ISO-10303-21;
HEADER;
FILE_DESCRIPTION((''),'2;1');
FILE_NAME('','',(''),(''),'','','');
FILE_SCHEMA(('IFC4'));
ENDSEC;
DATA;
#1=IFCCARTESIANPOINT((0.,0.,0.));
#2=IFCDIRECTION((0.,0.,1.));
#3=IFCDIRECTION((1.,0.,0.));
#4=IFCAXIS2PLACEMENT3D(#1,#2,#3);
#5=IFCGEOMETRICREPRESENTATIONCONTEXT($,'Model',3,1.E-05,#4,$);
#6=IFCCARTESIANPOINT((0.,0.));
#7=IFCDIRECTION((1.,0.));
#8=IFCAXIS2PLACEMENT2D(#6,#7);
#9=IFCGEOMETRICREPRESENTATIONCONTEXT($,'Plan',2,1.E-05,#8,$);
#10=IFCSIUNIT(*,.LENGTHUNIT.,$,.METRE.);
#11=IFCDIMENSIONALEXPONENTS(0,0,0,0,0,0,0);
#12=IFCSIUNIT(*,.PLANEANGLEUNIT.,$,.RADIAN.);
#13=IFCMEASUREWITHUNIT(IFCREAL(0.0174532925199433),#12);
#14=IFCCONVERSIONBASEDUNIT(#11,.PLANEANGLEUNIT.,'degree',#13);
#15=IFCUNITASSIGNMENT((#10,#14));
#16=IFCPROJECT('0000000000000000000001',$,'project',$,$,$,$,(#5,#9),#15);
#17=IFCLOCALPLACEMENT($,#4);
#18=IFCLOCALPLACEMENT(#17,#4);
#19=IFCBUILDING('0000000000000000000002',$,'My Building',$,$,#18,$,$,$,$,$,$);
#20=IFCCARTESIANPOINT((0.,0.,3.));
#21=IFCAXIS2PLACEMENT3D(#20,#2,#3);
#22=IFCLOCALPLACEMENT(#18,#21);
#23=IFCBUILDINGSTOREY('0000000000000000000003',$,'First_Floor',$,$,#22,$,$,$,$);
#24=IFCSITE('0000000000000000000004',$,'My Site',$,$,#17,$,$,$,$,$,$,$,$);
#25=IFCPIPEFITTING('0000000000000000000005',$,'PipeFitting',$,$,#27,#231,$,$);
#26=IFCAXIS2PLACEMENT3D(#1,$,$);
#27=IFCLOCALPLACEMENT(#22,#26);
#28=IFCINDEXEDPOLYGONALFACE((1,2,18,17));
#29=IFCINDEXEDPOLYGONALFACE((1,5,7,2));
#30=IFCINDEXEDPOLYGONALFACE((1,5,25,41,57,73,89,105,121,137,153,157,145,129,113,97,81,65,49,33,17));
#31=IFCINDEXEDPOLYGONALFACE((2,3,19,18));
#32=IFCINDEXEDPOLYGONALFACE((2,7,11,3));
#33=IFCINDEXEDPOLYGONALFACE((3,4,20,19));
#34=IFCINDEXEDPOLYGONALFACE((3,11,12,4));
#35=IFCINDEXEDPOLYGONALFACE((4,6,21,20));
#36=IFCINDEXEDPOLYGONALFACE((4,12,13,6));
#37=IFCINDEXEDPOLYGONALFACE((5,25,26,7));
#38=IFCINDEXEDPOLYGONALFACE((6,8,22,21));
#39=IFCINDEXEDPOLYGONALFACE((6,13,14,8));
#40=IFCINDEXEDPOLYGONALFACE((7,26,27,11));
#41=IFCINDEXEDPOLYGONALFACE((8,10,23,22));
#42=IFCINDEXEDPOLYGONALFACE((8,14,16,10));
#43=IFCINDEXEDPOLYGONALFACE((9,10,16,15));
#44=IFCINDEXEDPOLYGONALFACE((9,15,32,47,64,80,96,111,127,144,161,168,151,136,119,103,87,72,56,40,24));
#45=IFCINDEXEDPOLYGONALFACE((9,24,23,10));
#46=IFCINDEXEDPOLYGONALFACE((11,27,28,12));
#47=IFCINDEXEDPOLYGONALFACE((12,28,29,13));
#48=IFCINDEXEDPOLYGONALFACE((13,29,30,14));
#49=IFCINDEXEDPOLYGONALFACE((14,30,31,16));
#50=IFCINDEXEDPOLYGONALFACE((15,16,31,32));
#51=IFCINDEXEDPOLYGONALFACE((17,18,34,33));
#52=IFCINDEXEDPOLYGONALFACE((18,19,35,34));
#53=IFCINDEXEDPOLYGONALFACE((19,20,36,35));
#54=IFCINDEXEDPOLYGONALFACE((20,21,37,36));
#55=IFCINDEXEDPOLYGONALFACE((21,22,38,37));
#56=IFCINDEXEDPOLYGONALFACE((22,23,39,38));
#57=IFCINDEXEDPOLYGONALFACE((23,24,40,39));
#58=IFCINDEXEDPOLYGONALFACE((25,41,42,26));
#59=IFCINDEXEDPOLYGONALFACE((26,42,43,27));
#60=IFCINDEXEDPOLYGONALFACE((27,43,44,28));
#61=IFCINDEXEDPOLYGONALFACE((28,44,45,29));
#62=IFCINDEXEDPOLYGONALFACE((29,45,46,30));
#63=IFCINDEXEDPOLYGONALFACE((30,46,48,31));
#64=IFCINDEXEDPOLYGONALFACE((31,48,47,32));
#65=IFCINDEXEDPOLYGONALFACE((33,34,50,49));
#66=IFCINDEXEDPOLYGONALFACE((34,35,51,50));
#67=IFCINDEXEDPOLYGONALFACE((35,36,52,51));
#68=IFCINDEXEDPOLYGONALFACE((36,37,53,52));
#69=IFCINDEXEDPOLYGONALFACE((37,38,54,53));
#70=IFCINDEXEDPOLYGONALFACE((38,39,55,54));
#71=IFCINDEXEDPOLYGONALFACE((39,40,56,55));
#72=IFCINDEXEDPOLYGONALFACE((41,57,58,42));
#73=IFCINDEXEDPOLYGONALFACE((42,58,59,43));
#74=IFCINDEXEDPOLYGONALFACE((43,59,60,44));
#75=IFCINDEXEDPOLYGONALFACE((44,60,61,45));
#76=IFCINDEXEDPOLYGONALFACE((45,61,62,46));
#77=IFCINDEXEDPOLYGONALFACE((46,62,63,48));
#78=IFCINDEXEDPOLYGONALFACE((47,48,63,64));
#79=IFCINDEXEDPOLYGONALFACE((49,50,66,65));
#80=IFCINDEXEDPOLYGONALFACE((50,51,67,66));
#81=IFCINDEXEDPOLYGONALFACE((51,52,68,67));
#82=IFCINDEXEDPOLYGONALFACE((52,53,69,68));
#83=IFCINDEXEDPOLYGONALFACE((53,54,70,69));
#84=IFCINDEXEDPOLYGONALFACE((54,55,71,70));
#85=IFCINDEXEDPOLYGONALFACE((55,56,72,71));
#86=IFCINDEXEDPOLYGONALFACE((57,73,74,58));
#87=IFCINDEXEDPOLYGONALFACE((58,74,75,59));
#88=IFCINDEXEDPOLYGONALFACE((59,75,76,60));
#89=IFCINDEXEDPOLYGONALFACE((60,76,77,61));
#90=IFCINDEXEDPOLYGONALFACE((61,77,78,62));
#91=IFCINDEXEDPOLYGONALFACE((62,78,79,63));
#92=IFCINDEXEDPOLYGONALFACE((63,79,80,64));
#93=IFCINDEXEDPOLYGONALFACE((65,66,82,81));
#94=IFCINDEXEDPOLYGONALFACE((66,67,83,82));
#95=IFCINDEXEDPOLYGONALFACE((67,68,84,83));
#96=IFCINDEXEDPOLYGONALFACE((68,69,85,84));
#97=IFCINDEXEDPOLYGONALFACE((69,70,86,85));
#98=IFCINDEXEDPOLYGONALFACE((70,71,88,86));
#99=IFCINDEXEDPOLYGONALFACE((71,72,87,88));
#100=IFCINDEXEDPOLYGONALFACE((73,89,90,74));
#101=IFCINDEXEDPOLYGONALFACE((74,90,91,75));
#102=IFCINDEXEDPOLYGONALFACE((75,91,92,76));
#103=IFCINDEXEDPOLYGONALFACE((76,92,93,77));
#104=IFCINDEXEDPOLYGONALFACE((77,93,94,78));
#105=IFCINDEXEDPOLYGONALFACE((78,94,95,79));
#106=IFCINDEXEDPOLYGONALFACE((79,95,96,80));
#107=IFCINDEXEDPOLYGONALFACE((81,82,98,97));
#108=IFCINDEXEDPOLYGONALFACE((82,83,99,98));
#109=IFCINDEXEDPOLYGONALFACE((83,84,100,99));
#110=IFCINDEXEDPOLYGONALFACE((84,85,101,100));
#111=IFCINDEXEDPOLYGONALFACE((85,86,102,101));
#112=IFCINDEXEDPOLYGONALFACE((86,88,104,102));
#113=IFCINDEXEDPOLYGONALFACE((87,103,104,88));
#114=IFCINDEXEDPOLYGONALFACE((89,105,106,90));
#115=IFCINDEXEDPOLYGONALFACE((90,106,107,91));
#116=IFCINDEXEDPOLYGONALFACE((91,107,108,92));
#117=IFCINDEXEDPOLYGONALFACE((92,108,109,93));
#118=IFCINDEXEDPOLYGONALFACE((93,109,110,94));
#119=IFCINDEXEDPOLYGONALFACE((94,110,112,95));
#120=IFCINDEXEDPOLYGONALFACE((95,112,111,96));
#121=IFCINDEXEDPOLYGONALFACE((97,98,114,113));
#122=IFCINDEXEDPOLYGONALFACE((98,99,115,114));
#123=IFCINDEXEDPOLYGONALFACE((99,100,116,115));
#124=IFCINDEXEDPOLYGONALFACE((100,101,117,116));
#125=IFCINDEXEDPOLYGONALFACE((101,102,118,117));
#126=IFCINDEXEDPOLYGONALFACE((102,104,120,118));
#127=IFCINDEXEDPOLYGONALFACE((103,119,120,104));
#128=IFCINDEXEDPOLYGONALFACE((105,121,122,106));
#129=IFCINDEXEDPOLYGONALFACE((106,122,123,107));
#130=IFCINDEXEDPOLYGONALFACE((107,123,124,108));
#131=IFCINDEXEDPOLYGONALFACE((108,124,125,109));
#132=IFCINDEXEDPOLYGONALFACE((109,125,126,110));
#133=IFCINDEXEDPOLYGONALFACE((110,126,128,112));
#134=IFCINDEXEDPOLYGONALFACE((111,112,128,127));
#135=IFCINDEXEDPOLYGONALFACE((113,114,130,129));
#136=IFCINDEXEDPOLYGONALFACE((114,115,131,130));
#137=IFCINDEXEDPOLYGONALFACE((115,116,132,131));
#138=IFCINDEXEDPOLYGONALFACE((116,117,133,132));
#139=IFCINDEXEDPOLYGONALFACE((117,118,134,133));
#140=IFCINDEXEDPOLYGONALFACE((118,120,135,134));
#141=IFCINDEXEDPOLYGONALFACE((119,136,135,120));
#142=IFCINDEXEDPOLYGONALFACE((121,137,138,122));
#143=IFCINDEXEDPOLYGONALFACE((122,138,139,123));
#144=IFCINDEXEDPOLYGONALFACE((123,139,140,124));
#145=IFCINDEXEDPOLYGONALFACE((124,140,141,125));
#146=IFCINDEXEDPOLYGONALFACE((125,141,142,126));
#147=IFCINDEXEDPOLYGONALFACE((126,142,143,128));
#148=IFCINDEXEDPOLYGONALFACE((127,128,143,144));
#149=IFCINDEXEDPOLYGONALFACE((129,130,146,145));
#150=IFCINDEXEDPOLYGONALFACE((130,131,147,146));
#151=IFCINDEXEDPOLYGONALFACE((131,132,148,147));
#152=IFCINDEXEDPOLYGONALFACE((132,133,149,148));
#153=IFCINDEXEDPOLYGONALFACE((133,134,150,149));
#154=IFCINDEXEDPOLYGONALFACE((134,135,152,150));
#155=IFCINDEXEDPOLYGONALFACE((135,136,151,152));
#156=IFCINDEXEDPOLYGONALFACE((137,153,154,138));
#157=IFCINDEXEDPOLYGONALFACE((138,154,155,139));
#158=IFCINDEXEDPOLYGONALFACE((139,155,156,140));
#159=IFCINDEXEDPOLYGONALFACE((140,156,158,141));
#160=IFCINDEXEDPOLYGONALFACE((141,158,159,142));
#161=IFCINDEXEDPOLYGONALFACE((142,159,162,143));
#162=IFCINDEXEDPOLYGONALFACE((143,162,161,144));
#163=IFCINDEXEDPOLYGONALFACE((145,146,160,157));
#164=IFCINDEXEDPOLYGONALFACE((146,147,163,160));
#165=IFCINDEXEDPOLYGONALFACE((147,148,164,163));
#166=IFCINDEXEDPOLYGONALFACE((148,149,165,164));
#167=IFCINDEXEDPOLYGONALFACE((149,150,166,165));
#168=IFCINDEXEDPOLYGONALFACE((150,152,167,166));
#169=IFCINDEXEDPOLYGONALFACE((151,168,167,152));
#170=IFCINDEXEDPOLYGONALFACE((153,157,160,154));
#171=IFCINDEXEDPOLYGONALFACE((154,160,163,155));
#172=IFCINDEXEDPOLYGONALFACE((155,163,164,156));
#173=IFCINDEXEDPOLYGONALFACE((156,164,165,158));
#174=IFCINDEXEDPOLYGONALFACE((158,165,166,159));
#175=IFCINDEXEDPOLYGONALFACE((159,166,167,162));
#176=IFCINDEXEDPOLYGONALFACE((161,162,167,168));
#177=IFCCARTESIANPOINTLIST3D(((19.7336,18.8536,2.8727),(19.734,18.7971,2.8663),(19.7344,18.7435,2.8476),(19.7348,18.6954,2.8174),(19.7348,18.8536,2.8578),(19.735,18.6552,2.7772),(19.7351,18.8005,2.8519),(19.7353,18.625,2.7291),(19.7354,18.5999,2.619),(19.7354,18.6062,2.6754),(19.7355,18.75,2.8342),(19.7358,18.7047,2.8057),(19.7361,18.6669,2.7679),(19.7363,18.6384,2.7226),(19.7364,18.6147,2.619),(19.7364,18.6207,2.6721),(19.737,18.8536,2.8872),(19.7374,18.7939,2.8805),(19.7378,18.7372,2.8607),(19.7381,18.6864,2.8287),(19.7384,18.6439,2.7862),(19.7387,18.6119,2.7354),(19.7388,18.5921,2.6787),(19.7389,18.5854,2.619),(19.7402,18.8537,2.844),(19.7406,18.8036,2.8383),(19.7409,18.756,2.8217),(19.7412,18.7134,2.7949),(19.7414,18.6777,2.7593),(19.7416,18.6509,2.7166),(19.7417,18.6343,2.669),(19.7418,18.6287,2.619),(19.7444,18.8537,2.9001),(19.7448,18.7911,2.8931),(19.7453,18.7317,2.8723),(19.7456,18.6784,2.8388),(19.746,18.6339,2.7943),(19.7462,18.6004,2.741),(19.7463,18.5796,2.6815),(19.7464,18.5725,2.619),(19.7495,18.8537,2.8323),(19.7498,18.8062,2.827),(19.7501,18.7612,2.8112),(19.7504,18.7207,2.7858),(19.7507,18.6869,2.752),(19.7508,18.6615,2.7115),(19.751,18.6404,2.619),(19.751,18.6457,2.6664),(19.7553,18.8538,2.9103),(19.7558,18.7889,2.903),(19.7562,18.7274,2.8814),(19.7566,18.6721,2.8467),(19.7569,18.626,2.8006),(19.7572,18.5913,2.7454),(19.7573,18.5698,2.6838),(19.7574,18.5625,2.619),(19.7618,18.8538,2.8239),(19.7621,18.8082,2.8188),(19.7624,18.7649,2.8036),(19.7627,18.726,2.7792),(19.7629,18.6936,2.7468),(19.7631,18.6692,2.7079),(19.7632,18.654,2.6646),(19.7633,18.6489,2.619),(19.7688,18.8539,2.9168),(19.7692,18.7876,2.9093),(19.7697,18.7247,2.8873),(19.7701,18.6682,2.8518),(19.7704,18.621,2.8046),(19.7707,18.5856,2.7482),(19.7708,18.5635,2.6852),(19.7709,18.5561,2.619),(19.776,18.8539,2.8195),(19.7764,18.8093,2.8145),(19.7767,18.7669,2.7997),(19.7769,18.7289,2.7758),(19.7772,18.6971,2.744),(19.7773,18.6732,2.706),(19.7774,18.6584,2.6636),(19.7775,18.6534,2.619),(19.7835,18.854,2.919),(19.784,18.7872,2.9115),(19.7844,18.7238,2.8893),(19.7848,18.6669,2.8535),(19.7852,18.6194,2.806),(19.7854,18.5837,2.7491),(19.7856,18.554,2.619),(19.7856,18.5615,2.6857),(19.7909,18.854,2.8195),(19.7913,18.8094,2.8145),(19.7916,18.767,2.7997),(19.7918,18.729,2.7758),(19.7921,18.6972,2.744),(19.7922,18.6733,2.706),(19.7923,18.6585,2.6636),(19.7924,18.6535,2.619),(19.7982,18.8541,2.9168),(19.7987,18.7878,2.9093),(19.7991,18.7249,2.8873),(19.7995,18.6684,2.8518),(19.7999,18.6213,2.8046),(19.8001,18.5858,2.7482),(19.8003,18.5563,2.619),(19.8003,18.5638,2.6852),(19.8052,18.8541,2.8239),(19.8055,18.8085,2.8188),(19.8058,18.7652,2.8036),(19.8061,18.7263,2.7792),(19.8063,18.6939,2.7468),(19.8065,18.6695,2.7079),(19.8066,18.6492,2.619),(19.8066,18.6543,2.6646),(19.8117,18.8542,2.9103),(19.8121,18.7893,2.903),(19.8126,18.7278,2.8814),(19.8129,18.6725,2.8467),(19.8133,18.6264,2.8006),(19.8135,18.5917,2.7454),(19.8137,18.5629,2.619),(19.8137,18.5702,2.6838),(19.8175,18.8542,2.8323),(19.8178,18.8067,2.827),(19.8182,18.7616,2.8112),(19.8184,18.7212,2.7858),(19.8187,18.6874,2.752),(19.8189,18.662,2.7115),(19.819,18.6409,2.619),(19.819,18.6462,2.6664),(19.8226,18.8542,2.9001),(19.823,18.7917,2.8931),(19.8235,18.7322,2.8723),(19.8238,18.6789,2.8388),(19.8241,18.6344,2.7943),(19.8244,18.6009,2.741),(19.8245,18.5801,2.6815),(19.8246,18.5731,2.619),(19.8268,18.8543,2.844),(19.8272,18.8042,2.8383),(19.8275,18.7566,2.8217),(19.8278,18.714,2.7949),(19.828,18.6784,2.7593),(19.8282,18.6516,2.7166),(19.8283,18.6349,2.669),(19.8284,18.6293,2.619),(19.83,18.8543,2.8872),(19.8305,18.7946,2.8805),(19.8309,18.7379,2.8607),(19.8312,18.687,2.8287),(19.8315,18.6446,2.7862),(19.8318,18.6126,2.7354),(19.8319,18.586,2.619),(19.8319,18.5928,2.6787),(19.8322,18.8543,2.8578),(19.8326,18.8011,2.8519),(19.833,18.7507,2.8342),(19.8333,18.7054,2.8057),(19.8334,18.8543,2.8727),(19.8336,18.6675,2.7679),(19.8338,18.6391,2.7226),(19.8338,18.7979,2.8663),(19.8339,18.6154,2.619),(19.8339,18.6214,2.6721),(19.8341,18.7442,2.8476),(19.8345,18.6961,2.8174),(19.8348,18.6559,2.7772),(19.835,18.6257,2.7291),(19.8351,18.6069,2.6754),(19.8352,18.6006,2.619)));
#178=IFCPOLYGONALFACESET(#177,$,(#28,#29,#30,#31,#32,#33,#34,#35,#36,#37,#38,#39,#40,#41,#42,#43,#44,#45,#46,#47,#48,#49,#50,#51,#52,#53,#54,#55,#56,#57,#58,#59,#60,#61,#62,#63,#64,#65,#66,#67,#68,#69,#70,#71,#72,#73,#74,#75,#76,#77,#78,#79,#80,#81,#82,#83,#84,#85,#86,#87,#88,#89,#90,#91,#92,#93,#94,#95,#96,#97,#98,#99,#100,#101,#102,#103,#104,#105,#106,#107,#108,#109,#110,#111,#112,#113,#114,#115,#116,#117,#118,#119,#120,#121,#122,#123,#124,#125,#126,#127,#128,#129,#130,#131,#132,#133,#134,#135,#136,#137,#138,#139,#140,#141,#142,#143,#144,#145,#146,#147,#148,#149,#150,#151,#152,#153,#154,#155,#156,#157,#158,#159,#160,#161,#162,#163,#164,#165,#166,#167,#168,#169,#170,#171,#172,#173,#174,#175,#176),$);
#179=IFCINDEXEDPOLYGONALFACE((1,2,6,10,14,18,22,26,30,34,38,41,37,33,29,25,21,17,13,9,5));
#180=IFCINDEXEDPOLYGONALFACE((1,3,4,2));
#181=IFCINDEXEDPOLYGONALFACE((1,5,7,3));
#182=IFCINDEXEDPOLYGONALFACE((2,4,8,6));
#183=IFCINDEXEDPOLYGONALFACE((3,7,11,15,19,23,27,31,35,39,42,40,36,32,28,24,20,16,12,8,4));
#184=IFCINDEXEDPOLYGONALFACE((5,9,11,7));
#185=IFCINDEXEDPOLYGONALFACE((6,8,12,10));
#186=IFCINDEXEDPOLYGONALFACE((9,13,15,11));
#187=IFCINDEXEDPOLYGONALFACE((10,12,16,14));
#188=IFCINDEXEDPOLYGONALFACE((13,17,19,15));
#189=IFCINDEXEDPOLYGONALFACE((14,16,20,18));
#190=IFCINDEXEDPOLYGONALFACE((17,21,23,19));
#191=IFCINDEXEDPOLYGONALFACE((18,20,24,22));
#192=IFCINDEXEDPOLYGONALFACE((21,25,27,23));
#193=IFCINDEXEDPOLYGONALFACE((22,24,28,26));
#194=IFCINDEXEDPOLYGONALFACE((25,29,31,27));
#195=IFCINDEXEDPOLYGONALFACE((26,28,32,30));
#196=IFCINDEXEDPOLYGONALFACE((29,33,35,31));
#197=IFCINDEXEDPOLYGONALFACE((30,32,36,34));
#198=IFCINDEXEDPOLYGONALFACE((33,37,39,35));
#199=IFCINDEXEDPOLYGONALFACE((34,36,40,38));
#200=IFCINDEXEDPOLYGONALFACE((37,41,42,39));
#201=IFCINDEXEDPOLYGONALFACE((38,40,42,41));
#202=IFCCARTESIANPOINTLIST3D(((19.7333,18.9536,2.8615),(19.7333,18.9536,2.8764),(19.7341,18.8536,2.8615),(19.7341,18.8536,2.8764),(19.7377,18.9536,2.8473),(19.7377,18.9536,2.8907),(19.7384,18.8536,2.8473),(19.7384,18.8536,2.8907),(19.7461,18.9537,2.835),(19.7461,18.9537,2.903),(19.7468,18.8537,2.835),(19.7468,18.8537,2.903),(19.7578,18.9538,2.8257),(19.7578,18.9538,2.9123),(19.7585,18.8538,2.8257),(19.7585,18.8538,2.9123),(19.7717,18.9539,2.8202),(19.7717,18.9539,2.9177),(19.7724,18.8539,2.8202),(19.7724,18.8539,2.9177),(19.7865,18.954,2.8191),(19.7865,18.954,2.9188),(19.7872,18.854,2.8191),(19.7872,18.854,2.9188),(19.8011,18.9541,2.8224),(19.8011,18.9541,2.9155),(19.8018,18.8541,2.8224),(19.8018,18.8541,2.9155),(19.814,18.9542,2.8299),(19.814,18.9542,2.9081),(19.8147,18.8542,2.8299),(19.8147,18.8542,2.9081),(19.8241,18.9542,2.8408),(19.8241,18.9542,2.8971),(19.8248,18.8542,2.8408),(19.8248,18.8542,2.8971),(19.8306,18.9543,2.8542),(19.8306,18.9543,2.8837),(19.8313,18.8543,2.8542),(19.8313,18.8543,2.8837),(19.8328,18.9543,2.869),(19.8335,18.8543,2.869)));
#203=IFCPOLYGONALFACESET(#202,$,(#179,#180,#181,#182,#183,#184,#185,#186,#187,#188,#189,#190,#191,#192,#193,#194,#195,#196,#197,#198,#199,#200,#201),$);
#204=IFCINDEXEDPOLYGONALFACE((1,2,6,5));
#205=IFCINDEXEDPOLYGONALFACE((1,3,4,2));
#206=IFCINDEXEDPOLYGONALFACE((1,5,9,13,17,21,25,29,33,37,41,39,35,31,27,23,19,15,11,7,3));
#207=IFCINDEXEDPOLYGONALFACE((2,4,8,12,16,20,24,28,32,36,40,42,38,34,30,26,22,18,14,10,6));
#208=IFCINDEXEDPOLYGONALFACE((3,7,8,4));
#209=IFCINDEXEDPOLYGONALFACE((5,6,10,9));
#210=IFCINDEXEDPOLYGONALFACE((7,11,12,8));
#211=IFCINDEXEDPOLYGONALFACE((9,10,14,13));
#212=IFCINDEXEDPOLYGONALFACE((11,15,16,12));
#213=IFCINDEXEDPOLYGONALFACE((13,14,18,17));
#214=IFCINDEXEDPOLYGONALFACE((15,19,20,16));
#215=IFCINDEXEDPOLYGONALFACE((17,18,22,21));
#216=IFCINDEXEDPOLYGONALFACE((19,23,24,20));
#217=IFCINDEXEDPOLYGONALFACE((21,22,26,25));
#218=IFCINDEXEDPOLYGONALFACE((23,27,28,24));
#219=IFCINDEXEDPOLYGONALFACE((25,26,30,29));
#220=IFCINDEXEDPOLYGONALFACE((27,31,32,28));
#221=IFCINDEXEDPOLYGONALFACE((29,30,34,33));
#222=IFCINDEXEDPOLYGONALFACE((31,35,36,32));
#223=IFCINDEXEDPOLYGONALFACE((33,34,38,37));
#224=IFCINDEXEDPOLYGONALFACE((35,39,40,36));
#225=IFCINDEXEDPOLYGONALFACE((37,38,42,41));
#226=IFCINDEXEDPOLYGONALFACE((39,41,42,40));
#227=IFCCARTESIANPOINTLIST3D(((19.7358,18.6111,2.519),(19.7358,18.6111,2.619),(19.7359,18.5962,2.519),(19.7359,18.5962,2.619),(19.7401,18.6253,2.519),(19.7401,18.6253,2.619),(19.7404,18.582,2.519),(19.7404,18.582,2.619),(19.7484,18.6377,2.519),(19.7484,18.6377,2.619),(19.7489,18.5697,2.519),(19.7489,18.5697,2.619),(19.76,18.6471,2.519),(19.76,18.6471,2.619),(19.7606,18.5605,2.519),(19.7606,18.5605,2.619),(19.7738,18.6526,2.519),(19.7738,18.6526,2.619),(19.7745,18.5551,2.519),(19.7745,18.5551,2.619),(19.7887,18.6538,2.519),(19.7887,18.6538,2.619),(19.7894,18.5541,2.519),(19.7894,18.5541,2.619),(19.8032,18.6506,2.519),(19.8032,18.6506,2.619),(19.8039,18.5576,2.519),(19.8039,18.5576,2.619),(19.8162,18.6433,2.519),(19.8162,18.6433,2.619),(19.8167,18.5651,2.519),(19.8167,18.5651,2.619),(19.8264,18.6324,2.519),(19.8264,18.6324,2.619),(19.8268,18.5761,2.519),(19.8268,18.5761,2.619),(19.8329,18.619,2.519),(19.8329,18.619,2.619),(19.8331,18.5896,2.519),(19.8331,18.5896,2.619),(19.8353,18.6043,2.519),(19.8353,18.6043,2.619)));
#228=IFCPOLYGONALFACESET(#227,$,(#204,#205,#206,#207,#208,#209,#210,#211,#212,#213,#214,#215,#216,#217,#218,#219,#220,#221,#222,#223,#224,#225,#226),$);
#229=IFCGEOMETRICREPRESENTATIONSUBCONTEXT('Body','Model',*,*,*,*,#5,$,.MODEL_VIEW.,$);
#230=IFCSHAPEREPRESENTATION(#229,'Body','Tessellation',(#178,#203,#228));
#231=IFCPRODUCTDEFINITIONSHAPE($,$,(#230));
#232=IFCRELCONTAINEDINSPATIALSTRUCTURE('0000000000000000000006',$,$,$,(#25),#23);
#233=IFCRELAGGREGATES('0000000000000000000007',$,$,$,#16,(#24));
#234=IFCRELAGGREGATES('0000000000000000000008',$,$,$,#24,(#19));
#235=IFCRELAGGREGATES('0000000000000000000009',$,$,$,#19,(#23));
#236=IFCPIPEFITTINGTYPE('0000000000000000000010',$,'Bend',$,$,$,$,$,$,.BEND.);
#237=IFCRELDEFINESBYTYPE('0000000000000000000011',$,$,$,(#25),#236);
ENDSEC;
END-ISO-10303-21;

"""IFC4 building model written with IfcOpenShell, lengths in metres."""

from ifc_helpers import new_model, entity, si_unit, converted_unit, frame, origin_with_axes, origin_2d_with_axis, place, context, subcontext, project, spatial, circle, extrude, source, transform, mapped, type_object, type_shapes, element, save


model = new_model("IFC4")

# Units and contexts
model_context = context("Model", 3, precision=1e-05, world=origin_with_axes())
plan_context = context("Plan", 2, precision=1e-05, world=origin_2d_with_axis())
body_context_1 = subcontext(model_context, "Body", "Model", "MODEL_VIEW")
ifc_project = project(units=[si_unit("LENGTHUNIT", "METRE"), converted_unit("PLANEANGLEUNIT", "degree", entity("IfcReal", 0.0174532925199433), si_unit("PLANEANGLEUNIT", "RADIAN"), dimensions=[0, 0, 0, 0, 0, 0, 0])], contexts=[model_context, plan_context])

# Site, building, storey
site_placement = place(None, origin_with_axes())
site = spatial("IfcSite", under=ifc_project, at=site_placement, Name="My Site")
building_placement = place(site_placement, origin_with_axes())
building = spatial("IfcBuilding", under=site, at=building_placement, Name="My Building")
storey_placement = place(building_placement, frame((0.0, 0.0, 3.0), z_axis=(0.0, 0.0, 1.0), x_axis=(1.0, 0.0, 0.0)))
storey = spatial("IfcBuildingStorey", under=building, at=storey_placement, Name="First_Floor")

# Pipe fitting
pipe_fitting_type = type_object("IfcPipeFittingType", Name="Bend", PredefinedType="BEND")
shared_shape_1 = source(origin_with_axes(), body_context_1, "Body", "SolidModel", [
    entity("IfcSweptDiskSolid", entity("IfcIndexedPolyCurve", entity("IfcCartesianPointList3D", [[0.0, 0.0, -0.1], [0.0, 0.0732, -0.2768], [0.0, 0.25, -0.35]]), [entity("IfcArcIndex", [1, 2, 3])]), 0.05),
    extrude(circle(Radius=0.05), origin_with_axes(), (0.0, 0.0, -1.0), 0.1),
    extrude(circle(Radius=0.05), frame((0.0, 0.25, -0.35), z_axis=(0.0, 1.0, 0.0), x_axis=(1.0, 0.0, 0.0)), (0.0, 0.0, 1.0), 0.1),
])
type_shapes(pipe_fitting_type, [shared_shape_1])
for number, where, z_axis, x_axis, name in (
    (1, (19.7828, 18.954, 2.869), (-0.007084, 0.999975, 0.0), (0.999975, 0.007084, 0.0), "PipeFitting"),
):
    element("IfcPipeFitting", number, at=place(storey_placement, frame(where, z_axis=z_axis, x_axis=x_axis)), inside=storey, type_object=pipe_fitting_type, Name=name, context=body_context_1, shape_type="MappedRepresentation", body=[
        mapped(shared_shape_1, transform((0.0, 0.0, 0.0), x_axis=(1.0, 0.0, 0.0), y_axis=(0.0, 1.0, 0.0), z_axis=(0.0, 0.0, 1.0), scale=1.0)),
    ])

save(model, "model.ifc")
